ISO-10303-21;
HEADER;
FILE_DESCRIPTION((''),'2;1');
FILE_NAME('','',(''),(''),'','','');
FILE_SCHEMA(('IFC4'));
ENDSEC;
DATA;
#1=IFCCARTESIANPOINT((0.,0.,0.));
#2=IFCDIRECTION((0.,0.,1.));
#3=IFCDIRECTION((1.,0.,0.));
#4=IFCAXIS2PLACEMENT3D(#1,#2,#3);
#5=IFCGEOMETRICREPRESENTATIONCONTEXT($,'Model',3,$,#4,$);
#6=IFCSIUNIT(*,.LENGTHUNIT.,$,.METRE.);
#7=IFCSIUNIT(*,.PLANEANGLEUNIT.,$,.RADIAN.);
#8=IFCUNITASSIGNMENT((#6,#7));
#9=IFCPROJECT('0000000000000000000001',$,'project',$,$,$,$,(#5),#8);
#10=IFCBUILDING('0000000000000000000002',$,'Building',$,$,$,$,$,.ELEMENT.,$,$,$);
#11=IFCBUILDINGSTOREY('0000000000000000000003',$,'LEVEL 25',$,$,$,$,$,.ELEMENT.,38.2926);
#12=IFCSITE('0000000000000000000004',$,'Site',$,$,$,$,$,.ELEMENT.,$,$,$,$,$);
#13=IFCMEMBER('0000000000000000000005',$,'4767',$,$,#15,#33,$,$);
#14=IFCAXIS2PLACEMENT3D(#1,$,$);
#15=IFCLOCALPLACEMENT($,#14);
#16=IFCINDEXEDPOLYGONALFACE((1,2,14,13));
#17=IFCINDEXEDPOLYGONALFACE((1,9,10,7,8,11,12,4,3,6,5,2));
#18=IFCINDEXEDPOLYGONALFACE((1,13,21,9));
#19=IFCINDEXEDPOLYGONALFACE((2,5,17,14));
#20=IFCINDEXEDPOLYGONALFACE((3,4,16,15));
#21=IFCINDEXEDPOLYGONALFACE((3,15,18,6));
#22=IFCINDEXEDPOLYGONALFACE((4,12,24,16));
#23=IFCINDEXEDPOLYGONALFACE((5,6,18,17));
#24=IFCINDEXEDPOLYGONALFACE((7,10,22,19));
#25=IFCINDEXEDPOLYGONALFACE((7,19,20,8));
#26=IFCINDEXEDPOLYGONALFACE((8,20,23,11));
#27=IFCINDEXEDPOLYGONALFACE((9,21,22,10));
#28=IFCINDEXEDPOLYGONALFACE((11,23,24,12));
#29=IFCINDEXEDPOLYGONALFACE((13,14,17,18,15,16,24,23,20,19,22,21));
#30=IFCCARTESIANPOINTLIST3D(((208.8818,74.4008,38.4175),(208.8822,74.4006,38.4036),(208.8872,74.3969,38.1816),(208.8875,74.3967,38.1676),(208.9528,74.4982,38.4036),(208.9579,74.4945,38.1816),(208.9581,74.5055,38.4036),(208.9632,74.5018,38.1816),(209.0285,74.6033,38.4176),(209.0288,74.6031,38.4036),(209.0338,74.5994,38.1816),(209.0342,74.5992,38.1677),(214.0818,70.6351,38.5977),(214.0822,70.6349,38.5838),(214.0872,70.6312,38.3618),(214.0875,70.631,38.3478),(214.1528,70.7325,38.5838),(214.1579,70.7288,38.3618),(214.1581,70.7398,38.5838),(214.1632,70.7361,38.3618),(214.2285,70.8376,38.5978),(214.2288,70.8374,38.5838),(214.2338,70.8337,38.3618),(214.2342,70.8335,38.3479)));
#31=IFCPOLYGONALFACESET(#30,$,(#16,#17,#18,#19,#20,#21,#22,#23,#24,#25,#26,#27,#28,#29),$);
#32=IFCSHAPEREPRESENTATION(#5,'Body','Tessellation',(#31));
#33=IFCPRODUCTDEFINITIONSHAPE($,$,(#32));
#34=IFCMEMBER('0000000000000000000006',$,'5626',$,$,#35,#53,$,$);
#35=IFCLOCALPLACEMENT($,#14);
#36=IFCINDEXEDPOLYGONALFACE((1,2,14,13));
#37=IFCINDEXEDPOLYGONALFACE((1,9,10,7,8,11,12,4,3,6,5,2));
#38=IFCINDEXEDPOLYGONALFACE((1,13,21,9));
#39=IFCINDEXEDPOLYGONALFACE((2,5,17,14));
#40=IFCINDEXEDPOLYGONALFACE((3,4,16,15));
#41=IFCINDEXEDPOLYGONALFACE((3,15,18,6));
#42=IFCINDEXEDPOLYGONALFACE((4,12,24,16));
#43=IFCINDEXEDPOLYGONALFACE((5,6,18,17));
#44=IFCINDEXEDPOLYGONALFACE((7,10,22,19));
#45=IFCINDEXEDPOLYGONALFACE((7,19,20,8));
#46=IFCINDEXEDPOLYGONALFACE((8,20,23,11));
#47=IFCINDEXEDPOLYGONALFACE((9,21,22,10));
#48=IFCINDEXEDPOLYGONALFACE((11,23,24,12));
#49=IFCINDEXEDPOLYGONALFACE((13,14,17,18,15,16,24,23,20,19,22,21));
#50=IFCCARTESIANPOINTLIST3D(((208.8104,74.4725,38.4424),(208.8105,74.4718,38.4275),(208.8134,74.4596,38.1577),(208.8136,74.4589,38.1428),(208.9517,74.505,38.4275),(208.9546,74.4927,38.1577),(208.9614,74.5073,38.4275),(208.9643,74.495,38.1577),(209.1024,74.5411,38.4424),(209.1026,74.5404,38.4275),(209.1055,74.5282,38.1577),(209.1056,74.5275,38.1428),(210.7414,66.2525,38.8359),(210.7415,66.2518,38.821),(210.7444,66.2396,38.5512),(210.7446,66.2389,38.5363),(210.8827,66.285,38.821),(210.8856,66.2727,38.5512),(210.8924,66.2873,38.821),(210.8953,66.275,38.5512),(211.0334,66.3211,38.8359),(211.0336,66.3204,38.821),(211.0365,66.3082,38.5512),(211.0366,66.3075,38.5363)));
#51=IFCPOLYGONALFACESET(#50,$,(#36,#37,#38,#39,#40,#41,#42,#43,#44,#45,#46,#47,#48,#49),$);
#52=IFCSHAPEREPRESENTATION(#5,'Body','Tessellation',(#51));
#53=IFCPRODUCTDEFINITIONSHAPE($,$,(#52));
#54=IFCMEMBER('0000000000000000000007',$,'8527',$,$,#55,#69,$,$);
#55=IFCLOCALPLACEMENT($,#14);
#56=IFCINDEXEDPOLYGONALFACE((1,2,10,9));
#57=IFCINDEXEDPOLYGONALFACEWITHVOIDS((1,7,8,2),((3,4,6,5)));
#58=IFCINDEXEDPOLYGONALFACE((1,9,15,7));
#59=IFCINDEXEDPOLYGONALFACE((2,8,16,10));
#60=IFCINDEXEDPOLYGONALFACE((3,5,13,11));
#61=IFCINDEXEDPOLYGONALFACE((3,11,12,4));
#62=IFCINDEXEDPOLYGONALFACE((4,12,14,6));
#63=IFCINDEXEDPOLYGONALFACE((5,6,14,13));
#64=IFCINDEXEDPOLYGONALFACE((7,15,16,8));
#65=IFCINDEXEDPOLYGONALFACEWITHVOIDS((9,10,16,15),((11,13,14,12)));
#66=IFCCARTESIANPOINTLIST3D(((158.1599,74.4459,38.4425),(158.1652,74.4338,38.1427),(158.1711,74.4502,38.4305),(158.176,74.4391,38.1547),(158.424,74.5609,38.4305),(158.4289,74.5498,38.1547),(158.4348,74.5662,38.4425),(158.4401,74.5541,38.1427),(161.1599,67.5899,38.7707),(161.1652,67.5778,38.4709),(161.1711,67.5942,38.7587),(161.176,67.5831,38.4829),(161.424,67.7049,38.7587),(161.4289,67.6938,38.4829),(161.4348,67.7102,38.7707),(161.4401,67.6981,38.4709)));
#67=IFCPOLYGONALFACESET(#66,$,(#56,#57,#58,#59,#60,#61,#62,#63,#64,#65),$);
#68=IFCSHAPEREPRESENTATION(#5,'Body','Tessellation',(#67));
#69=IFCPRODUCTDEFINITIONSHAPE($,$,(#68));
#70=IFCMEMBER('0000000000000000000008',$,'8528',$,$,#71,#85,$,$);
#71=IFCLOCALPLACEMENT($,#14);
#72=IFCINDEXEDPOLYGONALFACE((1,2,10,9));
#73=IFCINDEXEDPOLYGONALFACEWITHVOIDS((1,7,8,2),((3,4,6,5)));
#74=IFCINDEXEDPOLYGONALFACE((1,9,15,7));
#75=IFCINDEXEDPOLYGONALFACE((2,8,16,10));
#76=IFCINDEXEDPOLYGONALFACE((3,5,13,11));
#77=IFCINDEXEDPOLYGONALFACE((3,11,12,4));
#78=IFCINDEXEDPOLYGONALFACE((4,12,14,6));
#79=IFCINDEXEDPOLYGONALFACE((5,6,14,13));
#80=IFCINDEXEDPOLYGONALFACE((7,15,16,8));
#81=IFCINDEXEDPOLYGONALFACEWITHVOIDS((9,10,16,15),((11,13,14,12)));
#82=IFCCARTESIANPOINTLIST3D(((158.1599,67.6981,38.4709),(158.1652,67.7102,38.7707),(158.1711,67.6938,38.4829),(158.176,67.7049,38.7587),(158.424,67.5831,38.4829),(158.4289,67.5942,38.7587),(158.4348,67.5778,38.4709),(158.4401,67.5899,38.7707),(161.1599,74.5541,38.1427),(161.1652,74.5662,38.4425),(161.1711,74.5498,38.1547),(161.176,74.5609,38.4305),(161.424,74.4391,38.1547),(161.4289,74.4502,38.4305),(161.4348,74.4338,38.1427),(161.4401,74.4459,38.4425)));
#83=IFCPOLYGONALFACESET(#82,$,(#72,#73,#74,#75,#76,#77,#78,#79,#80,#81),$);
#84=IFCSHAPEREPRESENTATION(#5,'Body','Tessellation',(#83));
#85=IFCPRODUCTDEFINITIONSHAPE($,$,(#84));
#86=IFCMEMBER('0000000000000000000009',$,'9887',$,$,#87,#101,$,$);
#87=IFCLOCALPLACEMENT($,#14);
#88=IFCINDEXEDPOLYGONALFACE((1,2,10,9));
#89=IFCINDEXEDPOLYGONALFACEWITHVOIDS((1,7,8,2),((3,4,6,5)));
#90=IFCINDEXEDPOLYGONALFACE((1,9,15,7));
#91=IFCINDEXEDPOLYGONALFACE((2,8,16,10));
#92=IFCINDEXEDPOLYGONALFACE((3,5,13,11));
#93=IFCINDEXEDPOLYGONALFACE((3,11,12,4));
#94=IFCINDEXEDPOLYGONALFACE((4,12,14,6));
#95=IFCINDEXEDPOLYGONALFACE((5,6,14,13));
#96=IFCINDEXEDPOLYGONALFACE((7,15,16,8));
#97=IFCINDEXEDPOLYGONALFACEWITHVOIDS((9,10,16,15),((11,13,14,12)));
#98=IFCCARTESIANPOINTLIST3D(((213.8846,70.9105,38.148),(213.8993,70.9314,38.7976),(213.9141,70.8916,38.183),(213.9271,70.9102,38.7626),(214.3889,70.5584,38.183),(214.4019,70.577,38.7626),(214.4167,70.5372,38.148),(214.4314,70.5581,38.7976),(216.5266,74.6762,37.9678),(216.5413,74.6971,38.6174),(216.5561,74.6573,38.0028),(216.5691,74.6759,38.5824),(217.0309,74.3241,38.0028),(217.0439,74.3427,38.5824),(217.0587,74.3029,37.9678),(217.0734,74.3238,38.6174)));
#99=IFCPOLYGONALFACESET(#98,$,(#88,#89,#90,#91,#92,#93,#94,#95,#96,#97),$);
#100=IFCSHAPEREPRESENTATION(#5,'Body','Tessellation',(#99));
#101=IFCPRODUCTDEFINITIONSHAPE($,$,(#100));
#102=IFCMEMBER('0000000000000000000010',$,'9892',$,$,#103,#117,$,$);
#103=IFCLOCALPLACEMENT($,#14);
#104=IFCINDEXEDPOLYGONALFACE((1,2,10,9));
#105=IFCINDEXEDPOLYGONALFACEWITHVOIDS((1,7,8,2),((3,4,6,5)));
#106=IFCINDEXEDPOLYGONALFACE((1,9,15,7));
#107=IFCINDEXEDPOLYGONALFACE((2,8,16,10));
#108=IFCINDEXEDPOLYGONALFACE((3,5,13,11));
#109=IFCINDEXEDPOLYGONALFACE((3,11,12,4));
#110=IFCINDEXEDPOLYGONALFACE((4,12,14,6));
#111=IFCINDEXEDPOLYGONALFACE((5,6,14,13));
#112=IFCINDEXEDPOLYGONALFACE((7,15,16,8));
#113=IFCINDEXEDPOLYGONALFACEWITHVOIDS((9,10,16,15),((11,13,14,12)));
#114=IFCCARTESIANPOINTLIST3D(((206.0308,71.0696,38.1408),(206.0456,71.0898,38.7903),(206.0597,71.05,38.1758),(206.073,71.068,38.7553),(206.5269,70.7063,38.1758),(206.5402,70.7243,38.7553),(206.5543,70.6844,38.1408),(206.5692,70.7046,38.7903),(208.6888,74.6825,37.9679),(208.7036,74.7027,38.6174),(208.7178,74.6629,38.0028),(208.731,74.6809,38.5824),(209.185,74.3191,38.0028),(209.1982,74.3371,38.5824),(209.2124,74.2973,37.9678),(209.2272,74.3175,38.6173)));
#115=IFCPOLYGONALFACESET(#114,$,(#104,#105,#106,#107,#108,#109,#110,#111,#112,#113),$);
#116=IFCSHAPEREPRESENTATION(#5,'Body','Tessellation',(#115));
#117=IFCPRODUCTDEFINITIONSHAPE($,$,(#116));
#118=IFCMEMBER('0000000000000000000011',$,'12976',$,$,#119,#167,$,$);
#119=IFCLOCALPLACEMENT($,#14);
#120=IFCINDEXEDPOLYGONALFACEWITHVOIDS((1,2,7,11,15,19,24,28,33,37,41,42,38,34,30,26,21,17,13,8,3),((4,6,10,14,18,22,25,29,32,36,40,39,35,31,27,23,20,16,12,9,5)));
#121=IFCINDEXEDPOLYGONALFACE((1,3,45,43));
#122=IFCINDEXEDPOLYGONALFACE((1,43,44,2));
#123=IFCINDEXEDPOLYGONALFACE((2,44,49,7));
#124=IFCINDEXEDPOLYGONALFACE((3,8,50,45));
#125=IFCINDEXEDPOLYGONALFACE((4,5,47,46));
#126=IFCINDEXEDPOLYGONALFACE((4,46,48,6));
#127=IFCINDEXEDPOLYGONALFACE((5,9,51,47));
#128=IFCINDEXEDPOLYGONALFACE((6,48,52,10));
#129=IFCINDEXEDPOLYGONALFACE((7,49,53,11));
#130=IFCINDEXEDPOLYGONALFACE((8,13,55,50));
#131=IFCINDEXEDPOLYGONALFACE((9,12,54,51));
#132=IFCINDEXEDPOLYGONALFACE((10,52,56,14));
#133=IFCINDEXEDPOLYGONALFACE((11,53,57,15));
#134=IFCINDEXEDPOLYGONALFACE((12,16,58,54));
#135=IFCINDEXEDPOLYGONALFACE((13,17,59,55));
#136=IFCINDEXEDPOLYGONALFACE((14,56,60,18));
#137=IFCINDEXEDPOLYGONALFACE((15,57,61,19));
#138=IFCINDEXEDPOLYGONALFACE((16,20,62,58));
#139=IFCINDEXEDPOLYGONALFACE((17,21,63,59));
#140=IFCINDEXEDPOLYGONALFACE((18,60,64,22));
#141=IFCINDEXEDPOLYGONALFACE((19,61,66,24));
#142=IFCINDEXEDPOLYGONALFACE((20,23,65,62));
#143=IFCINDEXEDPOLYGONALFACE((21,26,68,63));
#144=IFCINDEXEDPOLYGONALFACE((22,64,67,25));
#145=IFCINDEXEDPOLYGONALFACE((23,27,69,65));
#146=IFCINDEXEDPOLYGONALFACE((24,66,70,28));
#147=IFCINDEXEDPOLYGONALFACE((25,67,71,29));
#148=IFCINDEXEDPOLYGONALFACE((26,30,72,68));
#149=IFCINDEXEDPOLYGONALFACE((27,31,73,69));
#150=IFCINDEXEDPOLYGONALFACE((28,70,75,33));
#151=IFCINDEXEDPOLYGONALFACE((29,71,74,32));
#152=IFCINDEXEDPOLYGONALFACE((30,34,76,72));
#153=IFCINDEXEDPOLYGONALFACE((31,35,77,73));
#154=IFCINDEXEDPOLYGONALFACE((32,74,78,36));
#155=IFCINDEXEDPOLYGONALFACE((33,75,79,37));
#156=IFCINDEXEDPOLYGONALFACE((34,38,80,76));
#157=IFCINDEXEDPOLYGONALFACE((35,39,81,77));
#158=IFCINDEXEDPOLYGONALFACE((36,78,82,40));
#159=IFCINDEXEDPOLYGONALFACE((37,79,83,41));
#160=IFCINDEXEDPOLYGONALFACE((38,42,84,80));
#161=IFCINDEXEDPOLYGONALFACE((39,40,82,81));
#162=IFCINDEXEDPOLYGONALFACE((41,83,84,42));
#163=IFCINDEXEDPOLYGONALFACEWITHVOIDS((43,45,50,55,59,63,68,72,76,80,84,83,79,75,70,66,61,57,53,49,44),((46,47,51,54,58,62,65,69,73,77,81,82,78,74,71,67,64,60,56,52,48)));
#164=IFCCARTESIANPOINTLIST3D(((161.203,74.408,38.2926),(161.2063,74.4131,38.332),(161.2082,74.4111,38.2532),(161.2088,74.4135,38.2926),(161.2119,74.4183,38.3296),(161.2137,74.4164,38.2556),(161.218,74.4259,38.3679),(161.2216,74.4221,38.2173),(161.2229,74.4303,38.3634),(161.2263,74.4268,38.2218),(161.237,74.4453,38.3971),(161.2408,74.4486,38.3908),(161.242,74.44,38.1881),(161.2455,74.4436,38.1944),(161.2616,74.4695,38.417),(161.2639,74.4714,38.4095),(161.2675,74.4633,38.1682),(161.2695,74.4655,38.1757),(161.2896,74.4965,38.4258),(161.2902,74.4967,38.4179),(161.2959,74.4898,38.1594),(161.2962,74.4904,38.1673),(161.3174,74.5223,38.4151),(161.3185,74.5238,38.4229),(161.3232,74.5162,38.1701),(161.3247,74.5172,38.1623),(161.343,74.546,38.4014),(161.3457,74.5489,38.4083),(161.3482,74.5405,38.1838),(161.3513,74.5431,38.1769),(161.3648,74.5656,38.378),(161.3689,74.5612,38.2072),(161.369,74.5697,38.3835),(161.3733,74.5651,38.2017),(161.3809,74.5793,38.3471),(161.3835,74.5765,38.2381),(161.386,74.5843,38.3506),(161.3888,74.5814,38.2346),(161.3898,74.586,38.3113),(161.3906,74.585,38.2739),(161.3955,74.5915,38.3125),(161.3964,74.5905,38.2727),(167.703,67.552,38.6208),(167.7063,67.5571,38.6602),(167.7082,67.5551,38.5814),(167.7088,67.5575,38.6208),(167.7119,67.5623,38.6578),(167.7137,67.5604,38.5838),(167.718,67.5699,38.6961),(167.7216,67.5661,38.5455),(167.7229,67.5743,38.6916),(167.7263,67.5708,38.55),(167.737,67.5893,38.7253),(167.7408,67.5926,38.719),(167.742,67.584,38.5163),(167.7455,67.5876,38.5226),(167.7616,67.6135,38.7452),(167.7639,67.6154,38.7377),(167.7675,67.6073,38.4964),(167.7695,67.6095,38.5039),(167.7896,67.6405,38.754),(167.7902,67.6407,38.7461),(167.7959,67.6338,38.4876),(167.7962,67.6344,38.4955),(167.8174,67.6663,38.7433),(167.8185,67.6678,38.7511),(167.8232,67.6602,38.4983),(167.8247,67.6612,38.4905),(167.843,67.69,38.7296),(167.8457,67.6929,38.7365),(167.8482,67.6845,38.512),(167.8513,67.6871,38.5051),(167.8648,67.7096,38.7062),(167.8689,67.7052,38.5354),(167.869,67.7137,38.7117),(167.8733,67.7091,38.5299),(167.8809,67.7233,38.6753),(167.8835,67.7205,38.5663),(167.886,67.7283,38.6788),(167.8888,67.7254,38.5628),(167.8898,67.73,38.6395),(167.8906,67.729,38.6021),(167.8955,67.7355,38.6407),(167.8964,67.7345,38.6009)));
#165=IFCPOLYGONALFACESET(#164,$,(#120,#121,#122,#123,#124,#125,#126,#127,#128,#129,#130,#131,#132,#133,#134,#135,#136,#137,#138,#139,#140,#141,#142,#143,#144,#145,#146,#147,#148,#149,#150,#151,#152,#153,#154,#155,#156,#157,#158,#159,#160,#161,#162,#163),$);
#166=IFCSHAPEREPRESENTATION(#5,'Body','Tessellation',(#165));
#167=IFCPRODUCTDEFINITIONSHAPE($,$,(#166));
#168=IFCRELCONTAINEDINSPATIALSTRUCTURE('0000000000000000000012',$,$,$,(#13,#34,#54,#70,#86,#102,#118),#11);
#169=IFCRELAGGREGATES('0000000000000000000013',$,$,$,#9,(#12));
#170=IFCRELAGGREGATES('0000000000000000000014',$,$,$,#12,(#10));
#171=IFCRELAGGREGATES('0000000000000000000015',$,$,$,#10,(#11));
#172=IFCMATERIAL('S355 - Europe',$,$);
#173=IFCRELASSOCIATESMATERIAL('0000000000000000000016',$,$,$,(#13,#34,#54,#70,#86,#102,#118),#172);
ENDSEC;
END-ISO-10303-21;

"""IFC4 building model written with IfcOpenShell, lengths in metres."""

from ifc_helpers import new_model, si_unit, frame, origin_with_axes, origin_2d_with_axis, place, context, project, spatial, hollow_rectangle, hollow_circle, i_section, extrude, material, material_profile, profile_set, profile_usage, element, save


model = new_model("IFC4")

# Units and contexts
model_context = context("Model", 3, world=origin_with_axes())
ifc_project = project(units=[si_unit("LENGTHUNIT", "METRE"), si_unit("PLANEANGLEUNIT", "RADIAN")], contexts=[model_context])

# Site, building, storey
site = spatial("IfcSite", under=ifc_project, Name="Site", CompositionType="ELEMENT")
building = spatial("IfcBuilding", under=site, Name="Building", CompositionType="ELEMENT")
storey = spatial("IfcBuildingStorey", under=building, Name="LEVEL 25", CompositionType="ELEMENT", Elevation=38.2926)

# Shared definitions
ifc_material = material(Name="S355 - Europe")

# Members
ifc_material_profile_1 = material_profile(ifc_material, i_section(OverallWidth=0.25, OverallDepth=0.25, WebThickness=0.009, FlangeThickness=0.014, at=origin_2d_with_axis()))
ifc_profile_set_1 = profile_set([ifc_material_profile_1])
ifc_profile_usage_1 = profile_usage(ifc_profile_set_1, cardinal=10)
member_1_placement = place(None, frame((208.958, 74.5, 38.2926), z_axis=(0.80961, -0.586298, 0.028056), x_axis=(0.585773, 0.810475, 0.0)))
element("IfcMember", 1, at=member_1_placement, inside=storey, material=ifc_profile_usage_1, Name="4767", context=model_context, shape_type="SweptSolid", body=[
    extrude(i_section(OverallWidth=0.25, OverallDepth=0.25, WebThickness=0.009, FlangeThickness=0.014, at=origin_2d_with_axis()), origin_with_axes(), (0.0, 0.0, 1.0), 6.4228),
])
ifc_material_profile_2 = material_profile(ifc_material, i_section(OverallWidth=0.3, OverallDepth=0.3, WebThickness=0.01, FlangeThickness=0.015, at=origin_2d_with_axis()))
ifc_profile_set_2 = profile_set([ifc_material_profile_2])
ifc_profile_usage_2 = profile_usage(ifc_profile_set_2, cardinal=10)
member_2_placement = place(None, frame((208.958, 74.5, 38.2926), z_axis=(0.228442, -0.972444, 0.046552), x_axis=(0.973499, 0.228689, 0.0)))
element("IfcMember", 2, at=member_2_placement, inside=storey, material=ifc_profile_usage_2, Name="5626", context=model_context, shape_type="SweptSolid", body=[
    extrude(i_section(OverallWidth=0.3, OverallDepth=0.3, WebThickness=0.01, FlangeThickness=0.015, at=origin_2d_with_axis()), origin_with_axes(), (0.0, 0.0, 1.0), 8.4529),
])
ifc_material_profile_3 = material_profile(ifc_material, hollow_rectangle(XDim=0.3, YDim=0.3, WallThickness=0.012, at=origin_2d_with_axis()))
ifc_profile_set_3 = profile_set([ifc_material_profile_3])
ifc_profile_usage_3 = profile_usage(ifc_profile_set_3, cardinal=10)
member_3_placement = place(None, frame((158.3, 74.5, 38.2926), z_axis=(0.40049, -0.915253, 0.043814), x_axis=(0.916133, 0.400875, 0.0)))
element("IfcMember", 3, at=member_3_placement, inside=storey, material=ifc_profile_usage_3, Name="8527", context=model_context, shape_type="SweptSolid", body=[
    extrude(hollow_rectangle(XDim=0.3, YDim=0.3, WallThickness=0.012, at=origin_2d_with_axis()), origin_with_axes(), (0.0, 0.0, 1.0), 7.4908),
])
ifc_material_profile_4 = material_profile(ifc_material, hollow_rectangle(XDim=0.3, YDim=0.3, WallThickness=0.012, at=origin_2d_with_axis()))
ifc_profile_set_4 = profile_set([ifc_material_profile_4])
ifc_profile_usage_4 = profile_usage(ifc_profile_set_4, cardinal=10)
member_4_placement = place(None, frame((158.3, 67.644, 38.6208), z_axis=(0.40049, 0.915253, -0.043814), x_axis=(-0.916133, 0.400875, 0.0)))
element("IfcMember", 4, at=member_4_placement, inside=storey, material=ifc_profile_usage_4, Name="8528", context=model_context, shape_type="SweptSolid", body=[
    extrude(hollow_rectangle(XDim=0.3, YDim=0.3, WallThickness=0.012, at=origin_2d_with_axis()), origin_with_axes(), (0.0, 0.0, 1.0), 7.4908),
])
ifc_material_profile_5 = material_profile(ifc_material, hollow_rectangle(XDim=0.65, YDim=0.65, WallThickness=0.035, at=origin_2d_with_axis()))
ifc_profile_set_5 = profile_set([ifc_material_profile_5])
ifc_profile_usage_5 = profile_usage(ifc_profile_set_5, cardinal=10)
member_5_placement = place(None, frame((214.158, 70.7343, 38.4728), z_axis=(0.573899, 0.81799, -0.039143), x_axis=(-0.818618, 0.574339, 0.0)))
element("IfcMember", 5, at=member_5_placement, inside=storey, material=ifc_profile_usage_5, Name="9887", context=model_context, shape_type="SweptSolid", body=[
    extrude(hollow_rectangle(XDim=0.65, YDim=0.65, WallThickness=0.035, at=origin_2d_with_axis()), origin_with_axes(), (0.0, 0.0, 1.0), 4.6036),
])
ifc_material_profile_6 = material_profile(ifc_material, hollow_rectangle(XDim=0.65, YDim=0.65, WallThickness=0.035, at=origin_2d_with_axis()))
ifc_profile_set_6 = profile_set([ifc_material_profile_6])
ifc_profile_usage_6 = profile_usage(ifc_profile_set_6, cardinal=10)
member_6_placement = place(None, frame((208.958, 74.5, 38.2926), z_axis=(-0.592169, -0.804892, 0.038531), x_axis=(0.805056, -0.593199, 0.0)))
element("IfcMember", 6, at=member_6_placement, inside=storey, material=ifc_profile_usage_6, Name="9892", context=model_context, shape_type="SweptSolid", body=[
    extrude(hollow_rectangle(XDim=0.65, YDim=0.65, WallThickness=0.035, at=origin_2d_with_axis()), origin_with_axes(), (0.0, 0.0, 1.0), 4.4886),
])
ifc_material_profile_7 = material_profile(ifc_material, hollow_circle(Radius=0.1337, WallThickness=0.008, at=origin_2d_with_axis()))
ifc_profile_set_7 = profile_set([ifc_material_profile_7])
ifc_profile_usage_7 = profile_usage(ifc_profile_set_7, cardinal=10)
member_7_placement = place(None, frame((167.8, 67.644, 38.6208), z_axis=(-0.6876, 0.725259, -0.034719), x_axis=(-0.725697, -0.688015, 0.0)))
element("IfcMember", 7, at=member_7_placement, inside=storey, material=ifc_profile_usage_7, Name="12976", context=model_context, shape_type="SweptSolid", body=[
    extrude(hollow_circle(Radius=0.1337, WallThickness=0.008, at=origin_2d_with_axis()), origin_with_axes(), (0.0, 0.0, 1.0), 9.4532),
])

save(model, "model.ifc")
